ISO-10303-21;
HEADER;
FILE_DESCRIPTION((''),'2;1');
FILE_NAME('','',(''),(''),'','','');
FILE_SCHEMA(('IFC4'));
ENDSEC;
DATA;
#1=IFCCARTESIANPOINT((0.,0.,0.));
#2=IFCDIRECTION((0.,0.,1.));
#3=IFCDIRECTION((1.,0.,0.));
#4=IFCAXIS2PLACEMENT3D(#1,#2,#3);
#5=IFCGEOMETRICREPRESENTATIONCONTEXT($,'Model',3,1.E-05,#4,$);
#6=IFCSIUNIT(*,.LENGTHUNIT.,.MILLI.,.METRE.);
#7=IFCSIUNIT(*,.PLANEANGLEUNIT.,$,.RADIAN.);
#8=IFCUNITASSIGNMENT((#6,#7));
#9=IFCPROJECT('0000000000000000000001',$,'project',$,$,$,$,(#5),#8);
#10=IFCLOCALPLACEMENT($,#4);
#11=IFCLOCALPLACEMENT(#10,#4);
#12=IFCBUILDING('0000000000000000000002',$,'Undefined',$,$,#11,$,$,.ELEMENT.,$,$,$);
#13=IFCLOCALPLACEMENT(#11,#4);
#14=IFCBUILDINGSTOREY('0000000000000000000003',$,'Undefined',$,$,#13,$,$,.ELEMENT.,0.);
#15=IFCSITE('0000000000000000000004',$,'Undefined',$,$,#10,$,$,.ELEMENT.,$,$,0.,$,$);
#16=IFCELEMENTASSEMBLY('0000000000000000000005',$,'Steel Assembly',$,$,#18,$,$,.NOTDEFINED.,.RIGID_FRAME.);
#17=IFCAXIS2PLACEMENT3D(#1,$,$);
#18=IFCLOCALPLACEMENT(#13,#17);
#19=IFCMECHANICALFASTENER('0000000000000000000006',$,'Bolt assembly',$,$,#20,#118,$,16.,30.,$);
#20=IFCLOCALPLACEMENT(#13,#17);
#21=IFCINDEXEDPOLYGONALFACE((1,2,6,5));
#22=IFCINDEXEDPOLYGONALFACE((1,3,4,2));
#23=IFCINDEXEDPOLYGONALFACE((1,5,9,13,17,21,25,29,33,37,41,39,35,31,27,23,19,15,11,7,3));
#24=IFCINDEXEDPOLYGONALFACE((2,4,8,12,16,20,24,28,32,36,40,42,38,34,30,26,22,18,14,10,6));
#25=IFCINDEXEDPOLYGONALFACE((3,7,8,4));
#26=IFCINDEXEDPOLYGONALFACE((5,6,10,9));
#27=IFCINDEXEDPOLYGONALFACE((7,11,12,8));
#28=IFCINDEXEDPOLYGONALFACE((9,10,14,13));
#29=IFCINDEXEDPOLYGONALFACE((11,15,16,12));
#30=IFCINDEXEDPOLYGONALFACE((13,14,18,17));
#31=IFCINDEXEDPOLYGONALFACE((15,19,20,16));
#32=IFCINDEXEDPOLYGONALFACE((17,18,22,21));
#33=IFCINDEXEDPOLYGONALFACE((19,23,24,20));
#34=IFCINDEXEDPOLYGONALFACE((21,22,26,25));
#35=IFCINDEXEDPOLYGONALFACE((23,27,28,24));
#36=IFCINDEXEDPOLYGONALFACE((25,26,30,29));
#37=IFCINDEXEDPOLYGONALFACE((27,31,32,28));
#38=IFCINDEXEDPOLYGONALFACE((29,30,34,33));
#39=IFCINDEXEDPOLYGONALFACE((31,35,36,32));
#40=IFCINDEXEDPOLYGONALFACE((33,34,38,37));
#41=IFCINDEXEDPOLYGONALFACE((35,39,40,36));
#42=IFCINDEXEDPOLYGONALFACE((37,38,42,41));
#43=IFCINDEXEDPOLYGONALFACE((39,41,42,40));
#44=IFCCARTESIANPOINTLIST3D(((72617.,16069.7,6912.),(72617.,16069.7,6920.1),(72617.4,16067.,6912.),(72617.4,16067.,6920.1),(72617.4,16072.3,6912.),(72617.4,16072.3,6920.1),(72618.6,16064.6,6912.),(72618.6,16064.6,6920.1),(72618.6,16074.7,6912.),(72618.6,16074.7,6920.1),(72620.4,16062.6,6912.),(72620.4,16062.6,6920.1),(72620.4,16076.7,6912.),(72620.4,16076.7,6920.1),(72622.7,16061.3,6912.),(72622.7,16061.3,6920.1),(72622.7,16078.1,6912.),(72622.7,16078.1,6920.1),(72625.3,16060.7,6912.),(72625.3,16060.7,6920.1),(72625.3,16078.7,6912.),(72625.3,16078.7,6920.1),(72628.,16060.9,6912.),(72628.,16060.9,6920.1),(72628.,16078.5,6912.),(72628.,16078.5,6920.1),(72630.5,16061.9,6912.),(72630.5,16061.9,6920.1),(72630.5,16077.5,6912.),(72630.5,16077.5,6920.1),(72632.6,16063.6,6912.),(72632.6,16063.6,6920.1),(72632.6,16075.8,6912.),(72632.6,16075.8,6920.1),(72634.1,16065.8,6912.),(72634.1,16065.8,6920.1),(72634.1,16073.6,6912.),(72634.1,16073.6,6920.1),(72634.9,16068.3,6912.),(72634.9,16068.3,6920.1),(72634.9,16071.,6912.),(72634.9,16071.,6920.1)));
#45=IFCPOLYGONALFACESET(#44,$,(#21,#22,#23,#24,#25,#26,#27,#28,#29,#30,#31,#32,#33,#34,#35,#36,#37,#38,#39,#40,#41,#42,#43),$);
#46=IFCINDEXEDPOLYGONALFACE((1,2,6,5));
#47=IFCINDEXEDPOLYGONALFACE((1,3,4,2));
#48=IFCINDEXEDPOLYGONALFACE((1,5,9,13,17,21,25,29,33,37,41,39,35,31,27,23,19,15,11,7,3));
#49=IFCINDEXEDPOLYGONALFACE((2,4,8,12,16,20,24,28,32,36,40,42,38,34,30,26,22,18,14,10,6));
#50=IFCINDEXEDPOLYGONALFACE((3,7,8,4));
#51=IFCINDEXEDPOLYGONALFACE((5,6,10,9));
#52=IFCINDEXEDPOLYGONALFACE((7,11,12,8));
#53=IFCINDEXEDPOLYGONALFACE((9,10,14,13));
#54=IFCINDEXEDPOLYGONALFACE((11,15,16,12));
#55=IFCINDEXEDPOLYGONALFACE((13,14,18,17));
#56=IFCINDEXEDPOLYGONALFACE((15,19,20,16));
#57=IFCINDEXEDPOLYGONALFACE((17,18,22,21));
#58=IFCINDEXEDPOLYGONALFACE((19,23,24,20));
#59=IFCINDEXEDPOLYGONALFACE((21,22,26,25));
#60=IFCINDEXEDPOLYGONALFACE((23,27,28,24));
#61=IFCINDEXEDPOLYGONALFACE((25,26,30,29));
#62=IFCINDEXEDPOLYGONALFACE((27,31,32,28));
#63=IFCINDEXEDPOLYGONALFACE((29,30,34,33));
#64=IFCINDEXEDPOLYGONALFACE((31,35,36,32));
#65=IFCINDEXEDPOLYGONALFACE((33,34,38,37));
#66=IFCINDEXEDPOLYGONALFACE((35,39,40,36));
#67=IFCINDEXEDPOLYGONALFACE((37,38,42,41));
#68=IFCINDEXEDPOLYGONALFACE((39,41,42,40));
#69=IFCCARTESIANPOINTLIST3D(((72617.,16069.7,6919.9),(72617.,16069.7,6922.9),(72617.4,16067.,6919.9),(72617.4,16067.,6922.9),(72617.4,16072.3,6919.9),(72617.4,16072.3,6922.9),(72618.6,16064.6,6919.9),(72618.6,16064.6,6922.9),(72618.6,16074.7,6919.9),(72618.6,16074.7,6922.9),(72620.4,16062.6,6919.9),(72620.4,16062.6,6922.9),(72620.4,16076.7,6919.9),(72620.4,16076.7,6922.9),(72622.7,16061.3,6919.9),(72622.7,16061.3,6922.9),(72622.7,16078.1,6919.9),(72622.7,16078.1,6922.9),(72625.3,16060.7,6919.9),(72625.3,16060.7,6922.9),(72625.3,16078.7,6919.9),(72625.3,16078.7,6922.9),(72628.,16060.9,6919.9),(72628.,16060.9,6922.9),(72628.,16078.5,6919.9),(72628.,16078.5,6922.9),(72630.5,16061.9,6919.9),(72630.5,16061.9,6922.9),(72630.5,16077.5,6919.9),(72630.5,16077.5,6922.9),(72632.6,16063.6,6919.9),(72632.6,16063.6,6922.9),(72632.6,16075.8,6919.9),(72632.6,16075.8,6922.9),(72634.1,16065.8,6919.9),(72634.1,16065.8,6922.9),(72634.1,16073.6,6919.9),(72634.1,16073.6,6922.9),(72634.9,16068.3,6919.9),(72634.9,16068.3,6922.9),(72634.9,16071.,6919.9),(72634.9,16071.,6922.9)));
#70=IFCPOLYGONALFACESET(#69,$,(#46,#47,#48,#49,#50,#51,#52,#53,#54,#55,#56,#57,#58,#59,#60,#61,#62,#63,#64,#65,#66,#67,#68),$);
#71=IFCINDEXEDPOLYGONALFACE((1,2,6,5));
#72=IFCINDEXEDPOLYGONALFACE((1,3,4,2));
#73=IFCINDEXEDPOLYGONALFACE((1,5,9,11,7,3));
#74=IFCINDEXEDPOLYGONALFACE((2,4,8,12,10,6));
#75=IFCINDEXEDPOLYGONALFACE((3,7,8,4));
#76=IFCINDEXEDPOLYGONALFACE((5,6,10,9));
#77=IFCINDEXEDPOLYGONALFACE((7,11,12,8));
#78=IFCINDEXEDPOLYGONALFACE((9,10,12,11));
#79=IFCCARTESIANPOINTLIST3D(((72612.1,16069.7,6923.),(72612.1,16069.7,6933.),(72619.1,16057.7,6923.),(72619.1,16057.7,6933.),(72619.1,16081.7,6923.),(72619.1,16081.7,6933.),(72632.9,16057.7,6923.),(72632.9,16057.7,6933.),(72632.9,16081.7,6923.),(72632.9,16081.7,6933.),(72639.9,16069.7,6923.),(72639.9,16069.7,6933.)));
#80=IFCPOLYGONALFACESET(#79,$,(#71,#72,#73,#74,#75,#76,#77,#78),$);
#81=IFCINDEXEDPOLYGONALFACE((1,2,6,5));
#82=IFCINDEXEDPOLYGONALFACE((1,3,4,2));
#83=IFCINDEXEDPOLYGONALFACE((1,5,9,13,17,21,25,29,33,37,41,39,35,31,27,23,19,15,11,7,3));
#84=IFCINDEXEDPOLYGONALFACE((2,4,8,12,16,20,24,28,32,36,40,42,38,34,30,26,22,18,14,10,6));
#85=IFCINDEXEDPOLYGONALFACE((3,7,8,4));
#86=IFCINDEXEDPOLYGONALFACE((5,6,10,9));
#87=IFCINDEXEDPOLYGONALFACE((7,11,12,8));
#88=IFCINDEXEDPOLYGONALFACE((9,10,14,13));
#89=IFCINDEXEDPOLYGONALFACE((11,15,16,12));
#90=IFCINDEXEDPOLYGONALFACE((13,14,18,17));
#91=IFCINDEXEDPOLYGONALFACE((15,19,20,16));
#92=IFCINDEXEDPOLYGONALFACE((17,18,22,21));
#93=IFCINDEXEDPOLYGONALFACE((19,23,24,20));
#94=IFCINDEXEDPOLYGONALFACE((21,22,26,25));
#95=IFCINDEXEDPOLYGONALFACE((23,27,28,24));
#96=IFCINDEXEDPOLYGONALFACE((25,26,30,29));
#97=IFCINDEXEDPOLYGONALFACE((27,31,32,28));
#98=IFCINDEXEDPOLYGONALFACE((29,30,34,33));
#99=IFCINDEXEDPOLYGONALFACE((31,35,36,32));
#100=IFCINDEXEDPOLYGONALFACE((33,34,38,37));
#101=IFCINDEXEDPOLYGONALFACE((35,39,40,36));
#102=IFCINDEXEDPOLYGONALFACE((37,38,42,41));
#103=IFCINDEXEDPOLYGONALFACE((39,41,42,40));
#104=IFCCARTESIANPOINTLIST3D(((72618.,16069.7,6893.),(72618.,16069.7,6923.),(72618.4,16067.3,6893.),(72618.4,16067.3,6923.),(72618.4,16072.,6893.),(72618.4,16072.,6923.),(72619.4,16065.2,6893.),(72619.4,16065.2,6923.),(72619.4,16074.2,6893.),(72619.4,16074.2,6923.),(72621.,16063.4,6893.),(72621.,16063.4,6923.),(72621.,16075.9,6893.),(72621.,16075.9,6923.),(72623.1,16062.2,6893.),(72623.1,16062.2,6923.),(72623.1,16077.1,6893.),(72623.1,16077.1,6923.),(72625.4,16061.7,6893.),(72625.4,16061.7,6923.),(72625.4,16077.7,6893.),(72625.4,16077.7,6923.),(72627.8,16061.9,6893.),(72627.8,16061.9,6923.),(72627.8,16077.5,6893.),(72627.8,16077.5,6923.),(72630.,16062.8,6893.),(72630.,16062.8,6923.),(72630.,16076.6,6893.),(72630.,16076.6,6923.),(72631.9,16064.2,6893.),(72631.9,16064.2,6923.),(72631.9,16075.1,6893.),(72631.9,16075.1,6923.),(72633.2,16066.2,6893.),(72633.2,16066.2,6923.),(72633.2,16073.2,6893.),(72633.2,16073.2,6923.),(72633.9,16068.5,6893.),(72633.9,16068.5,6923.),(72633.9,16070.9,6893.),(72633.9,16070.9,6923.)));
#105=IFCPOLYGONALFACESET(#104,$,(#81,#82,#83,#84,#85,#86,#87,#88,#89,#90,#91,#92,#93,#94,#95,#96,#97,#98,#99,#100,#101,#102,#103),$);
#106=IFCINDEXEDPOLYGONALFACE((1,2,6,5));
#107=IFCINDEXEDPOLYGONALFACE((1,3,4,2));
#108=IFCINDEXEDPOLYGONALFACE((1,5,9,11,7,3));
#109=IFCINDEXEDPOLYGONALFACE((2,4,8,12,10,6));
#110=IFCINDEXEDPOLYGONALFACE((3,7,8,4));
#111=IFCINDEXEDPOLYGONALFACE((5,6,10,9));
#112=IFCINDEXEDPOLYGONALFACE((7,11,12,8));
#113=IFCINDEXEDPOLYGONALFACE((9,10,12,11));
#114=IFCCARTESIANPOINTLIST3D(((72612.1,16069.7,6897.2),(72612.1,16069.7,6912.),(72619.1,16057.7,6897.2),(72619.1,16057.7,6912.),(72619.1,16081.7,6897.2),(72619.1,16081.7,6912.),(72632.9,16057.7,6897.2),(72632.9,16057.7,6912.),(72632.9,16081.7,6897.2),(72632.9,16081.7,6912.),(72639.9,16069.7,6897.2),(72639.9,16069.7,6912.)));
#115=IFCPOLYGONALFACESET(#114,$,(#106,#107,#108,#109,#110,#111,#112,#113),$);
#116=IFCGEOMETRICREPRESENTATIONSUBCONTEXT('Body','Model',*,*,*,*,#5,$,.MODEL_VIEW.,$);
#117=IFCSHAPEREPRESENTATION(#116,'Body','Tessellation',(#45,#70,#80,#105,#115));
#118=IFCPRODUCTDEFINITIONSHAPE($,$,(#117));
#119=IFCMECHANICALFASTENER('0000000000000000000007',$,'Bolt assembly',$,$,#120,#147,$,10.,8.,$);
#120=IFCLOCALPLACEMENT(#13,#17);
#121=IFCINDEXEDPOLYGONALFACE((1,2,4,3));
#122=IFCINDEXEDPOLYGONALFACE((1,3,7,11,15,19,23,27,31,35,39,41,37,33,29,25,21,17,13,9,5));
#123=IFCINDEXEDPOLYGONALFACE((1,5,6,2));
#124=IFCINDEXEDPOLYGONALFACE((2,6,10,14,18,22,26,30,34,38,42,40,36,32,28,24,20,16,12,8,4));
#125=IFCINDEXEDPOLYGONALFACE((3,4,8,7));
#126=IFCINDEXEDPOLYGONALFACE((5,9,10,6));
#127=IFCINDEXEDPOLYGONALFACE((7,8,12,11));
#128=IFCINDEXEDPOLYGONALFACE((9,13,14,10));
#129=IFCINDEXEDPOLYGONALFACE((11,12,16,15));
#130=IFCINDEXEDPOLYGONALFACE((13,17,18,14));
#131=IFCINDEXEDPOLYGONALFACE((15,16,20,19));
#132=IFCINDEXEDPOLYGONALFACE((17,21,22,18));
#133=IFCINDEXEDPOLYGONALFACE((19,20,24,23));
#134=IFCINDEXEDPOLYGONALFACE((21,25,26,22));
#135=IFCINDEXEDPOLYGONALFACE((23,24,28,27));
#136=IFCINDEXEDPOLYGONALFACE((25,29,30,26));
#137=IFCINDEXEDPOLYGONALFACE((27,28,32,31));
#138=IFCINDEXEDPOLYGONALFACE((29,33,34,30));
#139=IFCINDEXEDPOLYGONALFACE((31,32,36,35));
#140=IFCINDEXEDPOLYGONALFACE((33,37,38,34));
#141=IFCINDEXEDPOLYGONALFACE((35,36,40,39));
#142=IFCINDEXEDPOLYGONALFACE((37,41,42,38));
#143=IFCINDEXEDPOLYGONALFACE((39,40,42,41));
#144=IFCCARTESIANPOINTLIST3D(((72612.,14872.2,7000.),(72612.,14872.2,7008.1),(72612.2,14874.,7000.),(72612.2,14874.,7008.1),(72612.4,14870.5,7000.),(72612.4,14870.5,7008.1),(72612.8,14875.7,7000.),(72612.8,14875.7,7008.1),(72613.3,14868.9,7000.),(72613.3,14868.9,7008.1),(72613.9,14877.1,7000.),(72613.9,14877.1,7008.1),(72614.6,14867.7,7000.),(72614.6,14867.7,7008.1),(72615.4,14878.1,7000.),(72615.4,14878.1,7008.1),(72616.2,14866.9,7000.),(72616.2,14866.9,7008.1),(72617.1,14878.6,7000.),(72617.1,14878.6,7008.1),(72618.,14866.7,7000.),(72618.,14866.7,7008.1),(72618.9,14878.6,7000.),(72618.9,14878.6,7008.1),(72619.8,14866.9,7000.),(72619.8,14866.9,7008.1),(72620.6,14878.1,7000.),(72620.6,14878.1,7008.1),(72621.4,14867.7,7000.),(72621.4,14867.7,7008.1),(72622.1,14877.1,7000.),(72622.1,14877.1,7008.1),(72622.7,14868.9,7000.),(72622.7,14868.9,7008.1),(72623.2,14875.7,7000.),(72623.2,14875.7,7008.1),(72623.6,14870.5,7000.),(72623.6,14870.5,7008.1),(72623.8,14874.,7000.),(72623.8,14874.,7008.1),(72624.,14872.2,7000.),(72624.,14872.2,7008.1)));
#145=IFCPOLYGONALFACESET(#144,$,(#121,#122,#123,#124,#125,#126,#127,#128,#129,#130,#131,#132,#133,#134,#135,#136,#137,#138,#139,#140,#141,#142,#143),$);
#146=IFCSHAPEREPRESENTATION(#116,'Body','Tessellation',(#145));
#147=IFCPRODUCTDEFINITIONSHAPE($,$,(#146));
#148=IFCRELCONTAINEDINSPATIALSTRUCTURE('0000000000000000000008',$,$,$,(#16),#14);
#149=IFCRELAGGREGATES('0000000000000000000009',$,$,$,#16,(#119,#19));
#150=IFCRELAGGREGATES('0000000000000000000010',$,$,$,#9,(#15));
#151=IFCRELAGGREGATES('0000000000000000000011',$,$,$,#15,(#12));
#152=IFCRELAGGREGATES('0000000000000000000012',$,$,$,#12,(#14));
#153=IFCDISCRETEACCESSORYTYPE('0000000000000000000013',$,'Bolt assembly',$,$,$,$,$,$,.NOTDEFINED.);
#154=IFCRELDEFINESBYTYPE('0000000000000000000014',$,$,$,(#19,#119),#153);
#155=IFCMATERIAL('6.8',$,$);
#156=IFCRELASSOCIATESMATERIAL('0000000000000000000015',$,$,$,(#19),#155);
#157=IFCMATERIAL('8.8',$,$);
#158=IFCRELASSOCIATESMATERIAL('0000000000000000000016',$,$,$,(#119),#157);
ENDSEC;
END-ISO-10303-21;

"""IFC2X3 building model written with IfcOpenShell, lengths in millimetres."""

from ifc_helpers import new_model, si_unit, frame, origin_with_axes, origin_2d_with_axis, place, context, subcontext, project, spatial, polyline, circle, outline, extrude, source, transform, mapped, material, type_object, element, aggregate, save


model = new_model("IFC2X3")

# Units and contexts
model_context = context("Model", 3, precision=1e-05, world=origin_with_axes())
body_context = subcontext(model_context, "Body", "Model", "MODEL_VIEW")
ifc_project = project(units=[si_unit("LENGTHUNIT", "METRE", prefix="MILLI"), si_unit("PLANEANGLEUNIT", "RADIAN")], contexts=[model_context])

# Site, building, storey
site_placement = place(None, origin_with_axes())
site = spatial("IfcSite", under=ifc_project, at=site_placement, Name="Undefined", CompositionType="ELEMENT", RefElevation=0.0)
building_placement = place(site_placement, origin_with_axes())
building = spatial("IfcBuilding", under=site, at=building_placement, Name="Undefined", CompositionType="ELEMENT")
storey_placement = place(building_placement, origin_with_axes())
storey = spatial("IfcBuildingStorey", under=building, at=storey_placement, Name="Undefined", CompositionType="ELEMENT", Elevation=0.0)

# Element assembly, mechanical fasteners
assembly_1_placement = place(storey_placement, origin_with_axes())
assembly_1 = element("IfcElementAssembly", 1, at=assembly_1_placement, inside=storey, Name="Steel Assembly", AssemblyPlace="NOTDEFINED", PredefinedType="RIGID_FRAME")
ifc_material_1 = material(Name="6.8")
discrete_accessory_type_1 = type_object("IfcDiscreteAccessoryType", Name="Bolt assembly")
shared_shape_1 = source(origin_with_axes(), body_context, "Body", "SweptSolid", [
    extrude(circle(Radius=9.0, at=origin_2d_with_axis()), frame((0.0, -0.1, 0.0), z_axis=(0.0, 1.0, 0.0), x_axis=(1.0, 0.0, 0.0)), (0.0, 0.0, 1.0), 8.1),
    extrude(circle(Radius=9.0, at=origin_2d_with_axis()), frame((0.0, -2.9, 0.0), z_axis=(0.0, 1.0, 0.0), x_axis=(1.0, 0.0, 0.0)), (0.0, 0.0, 1.0), 3.0),
    extrude(outline(polyline([(13.9, 0.0), (6.9, 12.0), (-6.9, 12.0), (-13.9, 0.0), (-6.9, -12.0), (6.9, -12.0), (13.9, 0.0)])), frame((0.0, -13.0, 0.0), z_axis=(0.0, 1.0, 0.0), x_axis=(1.0, 0.0, 0.0)), (0.0, 0.0, 1.0), 10.0),
    extrude(circle(Radius=8.0, at=origin_2d_with_axis()), frame((0.0, -3.0, 0.0), z_axis=(0.0, 1.0, 0.0), x_axis=(1.0, 0.0, 0.0)), (0.0, 0.0, 1.0), 30.0),
    extrude(outline(polyline([(13.9, 0.0), (6.9, 12.0), (-6.9, 12.0), (-13.9, 0.0), (-6.9, -12.0), (6.9, -12.0), (13.9, 0.0)])), frame((0.0, 8.0, 0.0), z_axis=(0.0, 1.0, 0.0), x_axis=(1.0, 0.0, 0.0)), (0.0, 0.0, 1.0), 14.8),
])
mechanical_fastener_1_placement = place(assembly_1_placement, frame((72626.0, 16069.7, 6920.0), z_axis=(0.0, -1.0, 0.0), x_axis=(-1.0, 0.0, 0.0)))
mechanical_fastener_1 = element("IfcMechanicalFastener", 2, at=mechanical_fastener_1_placement, type_object=discrete_accessory_type_1, material=ifc_material_1, Name="Bolt assembly", NominalDiameter=16.0, NominalLength=30.0, context=body_context, shape_type="MappedRepresentation", body=[
    mapped(shared_shape_1, transform((0.0, 0.0, 0.0))),
])
ifc_material_2 = material(Name="8.8")
shared_shape_2 = source(origin_with_axes(), body_context, "Body", "SweptSolid", [
    extrude(circle(Radius=6.0, at=origin_2d_with_axis()), frame((0.0, 0.0, 0.0), z_axis=(0.0, 1.0, 0.0), x_axis=(1.0, 0.0, 0.0)), (0.0, 0.0, 1.0), 8.1),
])
mechanical_fastener_2_placement = place(assembly_1_placement, frame((72618.0, 14872.7, 7000.0), z_axis=(-1.0, 0.0, 0.0), x_axis=(0.0, -1.0, 0.0)))
mechanical_fastener_2 = element("IfcMechanicalFastener", 3, at=mechanical_fastener_2_placement, type_object=discrete_accessory_type_1, material=ifc_material_2, Name="Bolt assembly", NominalDiameter=10.0, NominalLength=8.0, context=body_context, shape_type="MappedRepresentation", body=[
    mapped(shared_shape_2, transform((0.0, 0.0, 0.0))),
])
aggregate(assembly_1, [mechanical_fastener_2, mechanical_fastener_1])

save(model, "model.ifc")
